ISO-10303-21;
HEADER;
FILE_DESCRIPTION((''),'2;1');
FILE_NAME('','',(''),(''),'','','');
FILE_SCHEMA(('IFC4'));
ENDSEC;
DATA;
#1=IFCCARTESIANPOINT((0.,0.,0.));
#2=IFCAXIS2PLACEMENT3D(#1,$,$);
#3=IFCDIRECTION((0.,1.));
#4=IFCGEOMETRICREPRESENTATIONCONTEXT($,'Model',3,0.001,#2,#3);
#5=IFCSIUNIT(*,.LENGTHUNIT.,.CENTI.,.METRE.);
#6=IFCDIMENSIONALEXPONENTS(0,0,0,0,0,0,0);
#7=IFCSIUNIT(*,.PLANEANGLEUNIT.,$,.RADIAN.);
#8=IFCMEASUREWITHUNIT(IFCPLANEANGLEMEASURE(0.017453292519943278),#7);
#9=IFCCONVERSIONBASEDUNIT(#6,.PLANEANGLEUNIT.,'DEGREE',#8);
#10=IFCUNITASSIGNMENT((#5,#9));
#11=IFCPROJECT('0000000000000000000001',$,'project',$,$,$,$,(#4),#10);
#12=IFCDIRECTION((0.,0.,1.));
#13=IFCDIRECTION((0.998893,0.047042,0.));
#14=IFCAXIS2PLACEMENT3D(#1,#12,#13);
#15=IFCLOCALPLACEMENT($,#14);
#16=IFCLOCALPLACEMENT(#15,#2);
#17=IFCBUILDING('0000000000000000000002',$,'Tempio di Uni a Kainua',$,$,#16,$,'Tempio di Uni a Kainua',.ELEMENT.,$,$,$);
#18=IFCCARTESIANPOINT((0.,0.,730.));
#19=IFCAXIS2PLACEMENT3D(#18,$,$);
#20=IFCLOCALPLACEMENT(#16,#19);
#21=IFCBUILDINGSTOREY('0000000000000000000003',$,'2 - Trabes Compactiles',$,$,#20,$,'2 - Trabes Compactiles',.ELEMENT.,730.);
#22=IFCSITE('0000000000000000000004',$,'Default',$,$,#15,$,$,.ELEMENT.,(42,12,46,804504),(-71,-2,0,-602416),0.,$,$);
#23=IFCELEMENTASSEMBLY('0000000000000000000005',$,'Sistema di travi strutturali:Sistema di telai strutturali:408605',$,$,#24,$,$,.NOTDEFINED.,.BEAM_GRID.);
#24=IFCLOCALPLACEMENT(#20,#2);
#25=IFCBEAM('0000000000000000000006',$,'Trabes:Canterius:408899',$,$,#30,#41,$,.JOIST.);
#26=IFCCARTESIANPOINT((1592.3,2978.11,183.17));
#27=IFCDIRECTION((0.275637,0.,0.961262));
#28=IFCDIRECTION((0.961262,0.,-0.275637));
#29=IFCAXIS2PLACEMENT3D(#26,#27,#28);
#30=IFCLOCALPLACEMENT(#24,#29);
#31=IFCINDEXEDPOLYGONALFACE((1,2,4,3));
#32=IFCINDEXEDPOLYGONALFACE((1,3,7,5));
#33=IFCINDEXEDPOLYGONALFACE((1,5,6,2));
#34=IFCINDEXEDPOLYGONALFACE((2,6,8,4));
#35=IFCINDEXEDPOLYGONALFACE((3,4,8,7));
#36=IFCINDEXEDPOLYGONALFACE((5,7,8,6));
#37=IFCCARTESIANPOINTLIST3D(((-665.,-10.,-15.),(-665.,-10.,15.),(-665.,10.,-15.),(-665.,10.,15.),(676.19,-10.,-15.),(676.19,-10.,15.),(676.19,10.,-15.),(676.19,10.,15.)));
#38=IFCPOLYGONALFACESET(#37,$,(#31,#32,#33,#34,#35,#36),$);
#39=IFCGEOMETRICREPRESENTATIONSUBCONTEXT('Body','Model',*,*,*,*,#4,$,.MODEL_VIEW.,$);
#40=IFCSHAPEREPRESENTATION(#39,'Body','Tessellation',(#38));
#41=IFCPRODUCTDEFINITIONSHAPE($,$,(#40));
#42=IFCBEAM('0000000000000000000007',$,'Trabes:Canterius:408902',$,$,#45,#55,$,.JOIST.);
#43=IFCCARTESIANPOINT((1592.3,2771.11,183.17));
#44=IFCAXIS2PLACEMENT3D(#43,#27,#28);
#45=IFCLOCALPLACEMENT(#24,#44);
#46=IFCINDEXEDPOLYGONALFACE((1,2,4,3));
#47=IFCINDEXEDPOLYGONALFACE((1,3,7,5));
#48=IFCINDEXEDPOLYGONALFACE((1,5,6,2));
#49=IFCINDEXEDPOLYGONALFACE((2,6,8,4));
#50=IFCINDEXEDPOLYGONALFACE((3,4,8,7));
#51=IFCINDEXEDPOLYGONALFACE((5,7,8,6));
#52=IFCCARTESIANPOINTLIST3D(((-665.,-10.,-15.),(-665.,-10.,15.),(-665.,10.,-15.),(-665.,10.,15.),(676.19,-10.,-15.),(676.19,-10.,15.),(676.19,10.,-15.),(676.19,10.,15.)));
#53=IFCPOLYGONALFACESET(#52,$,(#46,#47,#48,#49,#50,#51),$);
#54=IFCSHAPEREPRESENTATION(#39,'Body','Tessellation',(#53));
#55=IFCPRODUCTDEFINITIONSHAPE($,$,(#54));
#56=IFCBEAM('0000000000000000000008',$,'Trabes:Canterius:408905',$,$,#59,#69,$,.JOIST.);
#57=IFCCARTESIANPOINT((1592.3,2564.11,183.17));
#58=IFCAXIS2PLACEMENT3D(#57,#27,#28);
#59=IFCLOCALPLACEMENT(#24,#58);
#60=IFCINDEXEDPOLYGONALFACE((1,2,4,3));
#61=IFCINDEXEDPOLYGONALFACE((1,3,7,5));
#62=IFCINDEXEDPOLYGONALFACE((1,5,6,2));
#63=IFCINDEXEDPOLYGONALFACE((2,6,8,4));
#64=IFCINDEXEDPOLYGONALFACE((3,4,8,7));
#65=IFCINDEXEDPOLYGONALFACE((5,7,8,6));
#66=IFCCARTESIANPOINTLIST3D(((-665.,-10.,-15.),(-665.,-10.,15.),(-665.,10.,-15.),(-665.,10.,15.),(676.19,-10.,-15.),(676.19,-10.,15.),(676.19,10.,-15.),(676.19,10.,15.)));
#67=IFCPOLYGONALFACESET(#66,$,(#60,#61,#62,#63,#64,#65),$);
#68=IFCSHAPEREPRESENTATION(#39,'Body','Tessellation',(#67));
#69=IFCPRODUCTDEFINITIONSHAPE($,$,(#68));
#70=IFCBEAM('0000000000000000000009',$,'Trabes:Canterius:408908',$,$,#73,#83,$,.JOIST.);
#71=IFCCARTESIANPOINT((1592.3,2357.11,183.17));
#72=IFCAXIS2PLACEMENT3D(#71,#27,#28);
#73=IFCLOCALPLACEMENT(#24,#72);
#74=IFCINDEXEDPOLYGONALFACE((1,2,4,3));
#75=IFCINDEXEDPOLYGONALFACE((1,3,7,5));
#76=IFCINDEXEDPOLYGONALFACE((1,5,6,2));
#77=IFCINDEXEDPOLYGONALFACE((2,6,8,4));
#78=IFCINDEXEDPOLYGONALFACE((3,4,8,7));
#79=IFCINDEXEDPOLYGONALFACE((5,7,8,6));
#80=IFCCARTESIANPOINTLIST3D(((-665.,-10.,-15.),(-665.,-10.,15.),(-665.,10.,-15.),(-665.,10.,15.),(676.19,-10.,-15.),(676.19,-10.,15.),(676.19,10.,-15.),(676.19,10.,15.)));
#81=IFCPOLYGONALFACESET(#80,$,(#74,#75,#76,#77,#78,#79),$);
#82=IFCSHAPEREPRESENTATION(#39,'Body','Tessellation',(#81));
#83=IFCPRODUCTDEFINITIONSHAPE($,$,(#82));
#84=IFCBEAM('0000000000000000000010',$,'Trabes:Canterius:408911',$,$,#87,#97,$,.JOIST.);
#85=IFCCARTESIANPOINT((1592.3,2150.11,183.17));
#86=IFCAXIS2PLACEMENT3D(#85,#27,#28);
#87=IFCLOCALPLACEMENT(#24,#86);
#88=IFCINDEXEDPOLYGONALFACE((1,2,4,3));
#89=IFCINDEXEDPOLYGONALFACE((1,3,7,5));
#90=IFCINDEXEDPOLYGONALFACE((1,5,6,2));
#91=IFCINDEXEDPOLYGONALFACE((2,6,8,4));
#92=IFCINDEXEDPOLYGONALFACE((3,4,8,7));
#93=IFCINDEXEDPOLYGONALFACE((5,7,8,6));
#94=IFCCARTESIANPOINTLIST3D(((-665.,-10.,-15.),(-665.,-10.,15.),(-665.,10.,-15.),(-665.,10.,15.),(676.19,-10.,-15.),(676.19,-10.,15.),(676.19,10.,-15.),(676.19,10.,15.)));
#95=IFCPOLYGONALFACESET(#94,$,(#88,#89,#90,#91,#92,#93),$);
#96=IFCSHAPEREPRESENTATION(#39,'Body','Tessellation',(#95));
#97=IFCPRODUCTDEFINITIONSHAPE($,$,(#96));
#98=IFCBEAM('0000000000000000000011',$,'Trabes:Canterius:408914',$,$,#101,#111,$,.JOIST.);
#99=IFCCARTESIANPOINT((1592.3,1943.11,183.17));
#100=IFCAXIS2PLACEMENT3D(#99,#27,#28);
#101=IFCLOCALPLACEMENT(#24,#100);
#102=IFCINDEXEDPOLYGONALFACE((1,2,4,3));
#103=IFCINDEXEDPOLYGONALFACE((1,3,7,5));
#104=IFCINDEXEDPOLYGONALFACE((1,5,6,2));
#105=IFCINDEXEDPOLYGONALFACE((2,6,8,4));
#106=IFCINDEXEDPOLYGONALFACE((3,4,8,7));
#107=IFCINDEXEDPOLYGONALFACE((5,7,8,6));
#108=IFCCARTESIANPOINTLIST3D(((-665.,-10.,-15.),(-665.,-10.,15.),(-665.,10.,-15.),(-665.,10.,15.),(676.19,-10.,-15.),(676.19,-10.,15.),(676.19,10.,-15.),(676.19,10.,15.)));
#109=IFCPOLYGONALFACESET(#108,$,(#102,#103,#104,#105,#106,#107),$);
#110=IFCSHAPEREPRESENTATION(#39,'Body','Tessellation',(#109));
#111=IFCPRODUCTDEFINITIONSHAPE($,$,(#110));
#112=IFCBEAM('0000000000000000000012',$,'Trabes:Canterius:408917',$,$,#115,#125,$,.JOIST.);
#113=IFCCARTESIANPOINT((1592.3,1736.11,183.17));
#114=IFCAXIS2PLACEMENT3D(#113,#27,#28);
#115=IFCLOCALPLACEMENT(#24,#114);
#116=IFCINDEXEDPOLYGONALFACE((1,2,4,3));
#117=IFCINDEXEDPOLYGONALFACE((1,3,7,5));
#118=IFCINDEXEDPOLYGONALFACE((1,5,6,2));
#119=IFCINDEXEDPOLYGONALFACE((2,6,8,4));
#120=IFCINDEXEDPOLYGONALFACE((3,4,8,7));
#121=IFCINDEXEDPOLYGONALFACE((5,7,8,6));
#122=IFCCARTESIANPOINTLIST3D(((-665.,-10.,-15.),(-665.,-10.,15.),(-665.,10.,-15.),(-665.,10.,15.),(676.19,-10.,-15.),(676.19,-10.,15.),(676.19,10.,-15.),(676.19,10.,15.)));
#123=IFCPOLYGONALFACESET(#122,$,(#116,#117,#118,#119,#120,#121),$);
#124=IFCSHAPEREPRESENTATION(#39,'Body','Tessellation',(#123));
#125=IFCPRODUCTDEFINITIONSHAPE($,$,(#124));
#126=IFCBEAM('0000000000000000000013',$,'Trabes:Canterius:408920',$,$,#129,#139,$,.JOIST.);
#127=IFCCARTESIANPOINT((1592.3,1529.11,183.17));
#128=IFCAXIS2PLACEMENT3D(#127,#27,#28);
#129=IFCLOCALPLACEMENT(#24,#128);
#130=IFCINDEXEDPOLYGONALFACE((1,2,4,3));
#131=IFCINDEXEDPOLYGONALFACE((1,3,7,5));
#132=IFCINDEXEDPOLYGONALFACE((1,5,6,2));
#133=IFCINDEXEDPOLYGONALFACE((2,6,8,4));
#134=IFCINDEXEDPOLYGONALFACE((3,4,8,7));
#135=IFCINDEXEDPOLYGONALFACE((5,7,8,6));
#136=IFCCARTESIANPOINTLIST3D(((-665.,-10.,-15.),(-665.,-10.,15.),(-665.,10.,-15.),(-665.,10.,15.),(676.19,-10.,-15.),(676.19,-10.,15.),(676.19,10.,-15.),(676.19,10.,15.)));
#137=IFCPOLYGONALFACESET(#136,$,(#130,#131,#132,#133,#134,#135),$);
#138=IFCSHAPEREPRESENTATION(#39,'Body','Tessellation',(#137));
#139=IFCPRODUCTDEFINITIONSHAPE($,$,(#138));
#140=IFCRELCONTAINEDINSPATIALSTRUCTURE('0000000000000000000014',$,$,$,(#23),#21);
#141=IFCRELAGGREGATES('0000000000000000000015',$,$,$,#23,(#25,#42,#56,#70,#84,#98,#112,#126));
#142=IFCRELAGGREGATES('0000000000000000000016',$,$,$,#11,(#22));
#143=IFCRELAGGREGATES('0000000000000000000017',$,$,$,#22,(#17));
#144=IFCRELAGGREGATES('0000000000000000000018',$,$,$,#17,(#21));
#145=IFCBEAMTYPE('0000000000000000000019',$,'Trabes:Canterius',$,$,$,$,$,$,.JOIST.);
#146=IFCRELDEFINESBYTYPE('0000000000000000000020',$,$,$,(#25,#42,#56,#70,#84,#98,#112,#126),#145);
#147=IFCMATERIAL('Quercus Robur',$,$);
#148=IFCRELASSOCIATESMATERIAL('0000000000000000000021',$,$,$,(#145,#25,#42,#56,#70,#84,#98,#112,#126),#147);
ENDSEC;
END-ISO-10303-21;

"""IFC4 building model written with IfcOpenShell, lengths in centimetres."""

from ifc_helpers import new_model, entity, si_unit, converted_unit, direction, frame, origin, origin_2d_with_axis, place, context, subcontext, project, spatial, rectangle, extrude, source, transform, mapped, material, material_profile, profile_set, profile_usage, type_object, type_shapes, element, aggregate, save


model = new_model("IFC4")

# Units and contexts
model_context = context("Model", 3, precision=0.001, world=origin(), true_north=direction((0.0, 1.0)))
body_context = subcontext(model_context, "Body", "Model", "MODEL_VIEW")
ifc_project = project(units=[si_unit("LENGTHUNIT", "METRE", prefix="CENTI"), converted_unit("PLANEANGLEUNIT", "DEGREE", entity("IfcPlaneAngleMeasure", 0.017453292519943278), si_unit("PLANEANGLEUNIT", "RADIAN"), dimensions=[0, 0, 0, 0, 0, 0, 0])], contexts=[model_context])

# Site, building, storey
site_placement = place(None, frame((0.0, 0.0, 0.0), z_axis=(0.0, 0.0, 1.0), x_axis=(0.998893, 0.047042, 0.0)))
site = spatial("IfcSite", under=ifc_project, at=site_placement, Name="Default", CompositionType="ELEMENT", RefLatitude=(42, 12, 46, 804504), RefLongitude=(-71, -2, 0, -602416), RefElevation=0.0)
building_placement = place(site_placement, origin())
building = spatial("IfcBuilding", under=site, at=building_placement, Name="Tempio di Uni a Kainua", LongName="Tempio di Uni a Kainua", CompositionType="ELEMENT")
storey_placement = place(building_placement, frame((0.0, 0.0, 730.0)))
storey = spatial("IfcBuildingStorey", under=building, at=storey_placement, Name="2 - Trabes Compactiles", LongName="2 - Trabes Compactiles", CompositionType="ELEMENT", Elevation=730.0)

# Element assembly, beams
assembly_1_placement = place(storey_placement, origin())
assembly_1 = element("IfcElementAssembly", 1, at=assembly_1_placement, inside=storey, Name="Sistema di travi strutturali:Sistema di telai strutturali:408605", AssemblyPlace="NOTDEFINED", PredefinedType="BEAM_GRID")
ifc_material = material(Name="Quercus Robur")
ifc_material_profile_1 = material_profile(ifc_material, rectangle(XDim=2590.0, YDim=20.0, at=origin_2d_with_axis()), Name="Canterius")
ifc_profile_set_1 = profile_set([ifc_material_profile_1], Name="Canterius")
ifc_profile_usage_1 = profile_usage(ifc_profile_set_1, cardinal=8)
beam_type_1 = type_object("IfcBeamType", Name="Trabes:Canterius", PredefinedType="JOIST", material=ifc_profile_set_1)
shared_shape_1 = source(origin(), body_context, "Body", "SweptSolid", [
    extrude(rectangle(XDim=1341.19, YDim=20.0, at=origin_2d_with_axis()), frame((5.6, 0.0, -15.0)), (0.0, 0.0, 1.0), 30.0),
])
type_shapes(beam_type_1, [shared_shape_1])
beam_1_placement = place(assembly_1_placement, frame((1592.3, 2978.11, 183.17), z_axis=(0.275637, 0.0, 0.961262), x_axis=(0.961262, 0.0, -0.275637)))
beam_1 = element("IfcBeam", 2, at=beam_1_placement, type_object=beam_type_1, material=ifc_profile_usage_1, Name="Trabes:Canterius:408899", PredefinedType="JOIST", context=body_context, shape_type="MappedRepresentation", body=[
    mapped(shared_shape_1, transform((0.0, 0.0, 0.0), scale=1.0)),
])
beam_2_placement = place(assembly_1_placement, frame((1592.3, 2771.11, 183.17), z_axis=(0.275637, 0.0, 0.961262), x_axis=(0.961262, 0.0, -0.275637)))
beam_2 = element("IfcBeam", 3, at=beam_2_placement, type_object=beam_type_1, material=ifc_profile_usage_1, Name="Trabes:Canterius:408902", PredefinedType="JOIST", context=body_context, shape_type="MappedRepresentation", body=[
    mapped(shared_shape_1, transform((0.0, 0.0, 0.0), scale=1.0)),
])
beam_3_placement = place(assembly_1_placement, frame((1592.3, 2564.11, 183.17), z_axis=(0.275637, 0.0, 0.961262), x_axis=(0.961262, 0.0, -0.275637)))
beam_3 = element("IfcBeam", 4, at=beam_3_placement, type_object=beam_type_1, material=ifc_profile_usage_1, Name="Trabes:Canterius:408905", PredefinedType="JOIST", context=body_context, shape_type="MappedRepresentation", body=[
    mapped(shared_shape_1, transform((0.0, 0.0, 0.0), scale=1.0)),
])
beam_4_placement = place(assembly_1_placement, frame((1592.3, 2357.11, 183.17), z_axis=(0.275637, 0.0, 0.961262), x_axis=(0.961262, 0.0, -0.275637)))
beam_4 = element("IfcBeam", 5, at=beam_4_placement, type_object=beam_type_1, material=ifc_profile_usage_1, Name="Trabes:Canterius:408908", PredefinedType="JOIST", context=body_context, shape_type="MappedRepresentation", body=[
    mapped(shared_shape_1, transform((0.0, 0.0, 0.0), scale=1.0)),
])
beam_5_placement = place(assembly_1_placement, frame((1592.3, 2150.11, 183.17), z_axis=(0.275637, 0.0, 0.961262), x_axis=(0.961262, 0.0, -0.275637)))
beam_5 = element("IfcBeam", 6, at=beam_5_placement, type_object=beam_type_1, material=ifc_profile_usage_1, Name="Trabes:Canterius:408911", PredefinedType="JOIST", context=body_context, shape_type="MappedRepresentation", body=[
    mapped(shared_shape_1, transform((0.0, 0.0, 0.0), scale=1.0)),
])
beam_6_placement = place(assembly_1_placement, frame((1592.3, 1943.11, 183.17), z_axis=(0.275637, 0.0, 0.961262), x_axis=(0.961262, 0.0, -0.275637)))
beam_6 = element("IfcBeam", 7, at=beam_6_placement, type_object=beam_type_1, material=ifc_profile_usage_1, Name="Trabes:Canterius:408914", PredefinedType="JOIST", context=body_context, shape_type="MappedRepresentation", body=[
    mapped(shared_shape_1, transform((0.0, 0.0, 0.0), scale=1.0)),
])
beam_7_placement = place(assembly_1_placement, frame((1592.3, 1736.11, 183.17), z_axis=(0.275637, 0.0, 0.961262), x_axis=(0.961262, 0.0, -0.275637)))
beam_7 = element("IfcBeam", 8, at=beam_7_placement, type_object=beam_type_1, material=ifc_profile_usage_1, Name="Trabes:Canterius:408917", PredefinedType="JOIST", context=body_context, shape_type="MappedRepresentation", body=[
    mapped(shared_shape_1, transform((0.0, 0.0, 0.0), scale=1.0)),
])
beam_8_placement = place(assembly_1_placement, frame((1592.3, 1529.11, 183.17), z_axis=(0.275637, 0.0, 0.961262), x_axis=(0.961262, 0.0, -0.275637)))
beam_8 = element("IfcBeam", 9, at=beam_8_placement, type_object=beam_type_1, material=ifc_profile_usage_1, Name="Trabes:Canterius:408920", PredefinedType="JOIST", context=body_context, shape_type="MappedRepresentation", body=[
    mapped(shared_shape_1, transform((0.0, 0.0, 0.0), scale=1.0)),
])
aggregate(assembly_1, [beam_1, beam_2, beam_3, beam_4, beam_5, beam_6, beam_7, beam_8])

save(model, "model.ifc")
